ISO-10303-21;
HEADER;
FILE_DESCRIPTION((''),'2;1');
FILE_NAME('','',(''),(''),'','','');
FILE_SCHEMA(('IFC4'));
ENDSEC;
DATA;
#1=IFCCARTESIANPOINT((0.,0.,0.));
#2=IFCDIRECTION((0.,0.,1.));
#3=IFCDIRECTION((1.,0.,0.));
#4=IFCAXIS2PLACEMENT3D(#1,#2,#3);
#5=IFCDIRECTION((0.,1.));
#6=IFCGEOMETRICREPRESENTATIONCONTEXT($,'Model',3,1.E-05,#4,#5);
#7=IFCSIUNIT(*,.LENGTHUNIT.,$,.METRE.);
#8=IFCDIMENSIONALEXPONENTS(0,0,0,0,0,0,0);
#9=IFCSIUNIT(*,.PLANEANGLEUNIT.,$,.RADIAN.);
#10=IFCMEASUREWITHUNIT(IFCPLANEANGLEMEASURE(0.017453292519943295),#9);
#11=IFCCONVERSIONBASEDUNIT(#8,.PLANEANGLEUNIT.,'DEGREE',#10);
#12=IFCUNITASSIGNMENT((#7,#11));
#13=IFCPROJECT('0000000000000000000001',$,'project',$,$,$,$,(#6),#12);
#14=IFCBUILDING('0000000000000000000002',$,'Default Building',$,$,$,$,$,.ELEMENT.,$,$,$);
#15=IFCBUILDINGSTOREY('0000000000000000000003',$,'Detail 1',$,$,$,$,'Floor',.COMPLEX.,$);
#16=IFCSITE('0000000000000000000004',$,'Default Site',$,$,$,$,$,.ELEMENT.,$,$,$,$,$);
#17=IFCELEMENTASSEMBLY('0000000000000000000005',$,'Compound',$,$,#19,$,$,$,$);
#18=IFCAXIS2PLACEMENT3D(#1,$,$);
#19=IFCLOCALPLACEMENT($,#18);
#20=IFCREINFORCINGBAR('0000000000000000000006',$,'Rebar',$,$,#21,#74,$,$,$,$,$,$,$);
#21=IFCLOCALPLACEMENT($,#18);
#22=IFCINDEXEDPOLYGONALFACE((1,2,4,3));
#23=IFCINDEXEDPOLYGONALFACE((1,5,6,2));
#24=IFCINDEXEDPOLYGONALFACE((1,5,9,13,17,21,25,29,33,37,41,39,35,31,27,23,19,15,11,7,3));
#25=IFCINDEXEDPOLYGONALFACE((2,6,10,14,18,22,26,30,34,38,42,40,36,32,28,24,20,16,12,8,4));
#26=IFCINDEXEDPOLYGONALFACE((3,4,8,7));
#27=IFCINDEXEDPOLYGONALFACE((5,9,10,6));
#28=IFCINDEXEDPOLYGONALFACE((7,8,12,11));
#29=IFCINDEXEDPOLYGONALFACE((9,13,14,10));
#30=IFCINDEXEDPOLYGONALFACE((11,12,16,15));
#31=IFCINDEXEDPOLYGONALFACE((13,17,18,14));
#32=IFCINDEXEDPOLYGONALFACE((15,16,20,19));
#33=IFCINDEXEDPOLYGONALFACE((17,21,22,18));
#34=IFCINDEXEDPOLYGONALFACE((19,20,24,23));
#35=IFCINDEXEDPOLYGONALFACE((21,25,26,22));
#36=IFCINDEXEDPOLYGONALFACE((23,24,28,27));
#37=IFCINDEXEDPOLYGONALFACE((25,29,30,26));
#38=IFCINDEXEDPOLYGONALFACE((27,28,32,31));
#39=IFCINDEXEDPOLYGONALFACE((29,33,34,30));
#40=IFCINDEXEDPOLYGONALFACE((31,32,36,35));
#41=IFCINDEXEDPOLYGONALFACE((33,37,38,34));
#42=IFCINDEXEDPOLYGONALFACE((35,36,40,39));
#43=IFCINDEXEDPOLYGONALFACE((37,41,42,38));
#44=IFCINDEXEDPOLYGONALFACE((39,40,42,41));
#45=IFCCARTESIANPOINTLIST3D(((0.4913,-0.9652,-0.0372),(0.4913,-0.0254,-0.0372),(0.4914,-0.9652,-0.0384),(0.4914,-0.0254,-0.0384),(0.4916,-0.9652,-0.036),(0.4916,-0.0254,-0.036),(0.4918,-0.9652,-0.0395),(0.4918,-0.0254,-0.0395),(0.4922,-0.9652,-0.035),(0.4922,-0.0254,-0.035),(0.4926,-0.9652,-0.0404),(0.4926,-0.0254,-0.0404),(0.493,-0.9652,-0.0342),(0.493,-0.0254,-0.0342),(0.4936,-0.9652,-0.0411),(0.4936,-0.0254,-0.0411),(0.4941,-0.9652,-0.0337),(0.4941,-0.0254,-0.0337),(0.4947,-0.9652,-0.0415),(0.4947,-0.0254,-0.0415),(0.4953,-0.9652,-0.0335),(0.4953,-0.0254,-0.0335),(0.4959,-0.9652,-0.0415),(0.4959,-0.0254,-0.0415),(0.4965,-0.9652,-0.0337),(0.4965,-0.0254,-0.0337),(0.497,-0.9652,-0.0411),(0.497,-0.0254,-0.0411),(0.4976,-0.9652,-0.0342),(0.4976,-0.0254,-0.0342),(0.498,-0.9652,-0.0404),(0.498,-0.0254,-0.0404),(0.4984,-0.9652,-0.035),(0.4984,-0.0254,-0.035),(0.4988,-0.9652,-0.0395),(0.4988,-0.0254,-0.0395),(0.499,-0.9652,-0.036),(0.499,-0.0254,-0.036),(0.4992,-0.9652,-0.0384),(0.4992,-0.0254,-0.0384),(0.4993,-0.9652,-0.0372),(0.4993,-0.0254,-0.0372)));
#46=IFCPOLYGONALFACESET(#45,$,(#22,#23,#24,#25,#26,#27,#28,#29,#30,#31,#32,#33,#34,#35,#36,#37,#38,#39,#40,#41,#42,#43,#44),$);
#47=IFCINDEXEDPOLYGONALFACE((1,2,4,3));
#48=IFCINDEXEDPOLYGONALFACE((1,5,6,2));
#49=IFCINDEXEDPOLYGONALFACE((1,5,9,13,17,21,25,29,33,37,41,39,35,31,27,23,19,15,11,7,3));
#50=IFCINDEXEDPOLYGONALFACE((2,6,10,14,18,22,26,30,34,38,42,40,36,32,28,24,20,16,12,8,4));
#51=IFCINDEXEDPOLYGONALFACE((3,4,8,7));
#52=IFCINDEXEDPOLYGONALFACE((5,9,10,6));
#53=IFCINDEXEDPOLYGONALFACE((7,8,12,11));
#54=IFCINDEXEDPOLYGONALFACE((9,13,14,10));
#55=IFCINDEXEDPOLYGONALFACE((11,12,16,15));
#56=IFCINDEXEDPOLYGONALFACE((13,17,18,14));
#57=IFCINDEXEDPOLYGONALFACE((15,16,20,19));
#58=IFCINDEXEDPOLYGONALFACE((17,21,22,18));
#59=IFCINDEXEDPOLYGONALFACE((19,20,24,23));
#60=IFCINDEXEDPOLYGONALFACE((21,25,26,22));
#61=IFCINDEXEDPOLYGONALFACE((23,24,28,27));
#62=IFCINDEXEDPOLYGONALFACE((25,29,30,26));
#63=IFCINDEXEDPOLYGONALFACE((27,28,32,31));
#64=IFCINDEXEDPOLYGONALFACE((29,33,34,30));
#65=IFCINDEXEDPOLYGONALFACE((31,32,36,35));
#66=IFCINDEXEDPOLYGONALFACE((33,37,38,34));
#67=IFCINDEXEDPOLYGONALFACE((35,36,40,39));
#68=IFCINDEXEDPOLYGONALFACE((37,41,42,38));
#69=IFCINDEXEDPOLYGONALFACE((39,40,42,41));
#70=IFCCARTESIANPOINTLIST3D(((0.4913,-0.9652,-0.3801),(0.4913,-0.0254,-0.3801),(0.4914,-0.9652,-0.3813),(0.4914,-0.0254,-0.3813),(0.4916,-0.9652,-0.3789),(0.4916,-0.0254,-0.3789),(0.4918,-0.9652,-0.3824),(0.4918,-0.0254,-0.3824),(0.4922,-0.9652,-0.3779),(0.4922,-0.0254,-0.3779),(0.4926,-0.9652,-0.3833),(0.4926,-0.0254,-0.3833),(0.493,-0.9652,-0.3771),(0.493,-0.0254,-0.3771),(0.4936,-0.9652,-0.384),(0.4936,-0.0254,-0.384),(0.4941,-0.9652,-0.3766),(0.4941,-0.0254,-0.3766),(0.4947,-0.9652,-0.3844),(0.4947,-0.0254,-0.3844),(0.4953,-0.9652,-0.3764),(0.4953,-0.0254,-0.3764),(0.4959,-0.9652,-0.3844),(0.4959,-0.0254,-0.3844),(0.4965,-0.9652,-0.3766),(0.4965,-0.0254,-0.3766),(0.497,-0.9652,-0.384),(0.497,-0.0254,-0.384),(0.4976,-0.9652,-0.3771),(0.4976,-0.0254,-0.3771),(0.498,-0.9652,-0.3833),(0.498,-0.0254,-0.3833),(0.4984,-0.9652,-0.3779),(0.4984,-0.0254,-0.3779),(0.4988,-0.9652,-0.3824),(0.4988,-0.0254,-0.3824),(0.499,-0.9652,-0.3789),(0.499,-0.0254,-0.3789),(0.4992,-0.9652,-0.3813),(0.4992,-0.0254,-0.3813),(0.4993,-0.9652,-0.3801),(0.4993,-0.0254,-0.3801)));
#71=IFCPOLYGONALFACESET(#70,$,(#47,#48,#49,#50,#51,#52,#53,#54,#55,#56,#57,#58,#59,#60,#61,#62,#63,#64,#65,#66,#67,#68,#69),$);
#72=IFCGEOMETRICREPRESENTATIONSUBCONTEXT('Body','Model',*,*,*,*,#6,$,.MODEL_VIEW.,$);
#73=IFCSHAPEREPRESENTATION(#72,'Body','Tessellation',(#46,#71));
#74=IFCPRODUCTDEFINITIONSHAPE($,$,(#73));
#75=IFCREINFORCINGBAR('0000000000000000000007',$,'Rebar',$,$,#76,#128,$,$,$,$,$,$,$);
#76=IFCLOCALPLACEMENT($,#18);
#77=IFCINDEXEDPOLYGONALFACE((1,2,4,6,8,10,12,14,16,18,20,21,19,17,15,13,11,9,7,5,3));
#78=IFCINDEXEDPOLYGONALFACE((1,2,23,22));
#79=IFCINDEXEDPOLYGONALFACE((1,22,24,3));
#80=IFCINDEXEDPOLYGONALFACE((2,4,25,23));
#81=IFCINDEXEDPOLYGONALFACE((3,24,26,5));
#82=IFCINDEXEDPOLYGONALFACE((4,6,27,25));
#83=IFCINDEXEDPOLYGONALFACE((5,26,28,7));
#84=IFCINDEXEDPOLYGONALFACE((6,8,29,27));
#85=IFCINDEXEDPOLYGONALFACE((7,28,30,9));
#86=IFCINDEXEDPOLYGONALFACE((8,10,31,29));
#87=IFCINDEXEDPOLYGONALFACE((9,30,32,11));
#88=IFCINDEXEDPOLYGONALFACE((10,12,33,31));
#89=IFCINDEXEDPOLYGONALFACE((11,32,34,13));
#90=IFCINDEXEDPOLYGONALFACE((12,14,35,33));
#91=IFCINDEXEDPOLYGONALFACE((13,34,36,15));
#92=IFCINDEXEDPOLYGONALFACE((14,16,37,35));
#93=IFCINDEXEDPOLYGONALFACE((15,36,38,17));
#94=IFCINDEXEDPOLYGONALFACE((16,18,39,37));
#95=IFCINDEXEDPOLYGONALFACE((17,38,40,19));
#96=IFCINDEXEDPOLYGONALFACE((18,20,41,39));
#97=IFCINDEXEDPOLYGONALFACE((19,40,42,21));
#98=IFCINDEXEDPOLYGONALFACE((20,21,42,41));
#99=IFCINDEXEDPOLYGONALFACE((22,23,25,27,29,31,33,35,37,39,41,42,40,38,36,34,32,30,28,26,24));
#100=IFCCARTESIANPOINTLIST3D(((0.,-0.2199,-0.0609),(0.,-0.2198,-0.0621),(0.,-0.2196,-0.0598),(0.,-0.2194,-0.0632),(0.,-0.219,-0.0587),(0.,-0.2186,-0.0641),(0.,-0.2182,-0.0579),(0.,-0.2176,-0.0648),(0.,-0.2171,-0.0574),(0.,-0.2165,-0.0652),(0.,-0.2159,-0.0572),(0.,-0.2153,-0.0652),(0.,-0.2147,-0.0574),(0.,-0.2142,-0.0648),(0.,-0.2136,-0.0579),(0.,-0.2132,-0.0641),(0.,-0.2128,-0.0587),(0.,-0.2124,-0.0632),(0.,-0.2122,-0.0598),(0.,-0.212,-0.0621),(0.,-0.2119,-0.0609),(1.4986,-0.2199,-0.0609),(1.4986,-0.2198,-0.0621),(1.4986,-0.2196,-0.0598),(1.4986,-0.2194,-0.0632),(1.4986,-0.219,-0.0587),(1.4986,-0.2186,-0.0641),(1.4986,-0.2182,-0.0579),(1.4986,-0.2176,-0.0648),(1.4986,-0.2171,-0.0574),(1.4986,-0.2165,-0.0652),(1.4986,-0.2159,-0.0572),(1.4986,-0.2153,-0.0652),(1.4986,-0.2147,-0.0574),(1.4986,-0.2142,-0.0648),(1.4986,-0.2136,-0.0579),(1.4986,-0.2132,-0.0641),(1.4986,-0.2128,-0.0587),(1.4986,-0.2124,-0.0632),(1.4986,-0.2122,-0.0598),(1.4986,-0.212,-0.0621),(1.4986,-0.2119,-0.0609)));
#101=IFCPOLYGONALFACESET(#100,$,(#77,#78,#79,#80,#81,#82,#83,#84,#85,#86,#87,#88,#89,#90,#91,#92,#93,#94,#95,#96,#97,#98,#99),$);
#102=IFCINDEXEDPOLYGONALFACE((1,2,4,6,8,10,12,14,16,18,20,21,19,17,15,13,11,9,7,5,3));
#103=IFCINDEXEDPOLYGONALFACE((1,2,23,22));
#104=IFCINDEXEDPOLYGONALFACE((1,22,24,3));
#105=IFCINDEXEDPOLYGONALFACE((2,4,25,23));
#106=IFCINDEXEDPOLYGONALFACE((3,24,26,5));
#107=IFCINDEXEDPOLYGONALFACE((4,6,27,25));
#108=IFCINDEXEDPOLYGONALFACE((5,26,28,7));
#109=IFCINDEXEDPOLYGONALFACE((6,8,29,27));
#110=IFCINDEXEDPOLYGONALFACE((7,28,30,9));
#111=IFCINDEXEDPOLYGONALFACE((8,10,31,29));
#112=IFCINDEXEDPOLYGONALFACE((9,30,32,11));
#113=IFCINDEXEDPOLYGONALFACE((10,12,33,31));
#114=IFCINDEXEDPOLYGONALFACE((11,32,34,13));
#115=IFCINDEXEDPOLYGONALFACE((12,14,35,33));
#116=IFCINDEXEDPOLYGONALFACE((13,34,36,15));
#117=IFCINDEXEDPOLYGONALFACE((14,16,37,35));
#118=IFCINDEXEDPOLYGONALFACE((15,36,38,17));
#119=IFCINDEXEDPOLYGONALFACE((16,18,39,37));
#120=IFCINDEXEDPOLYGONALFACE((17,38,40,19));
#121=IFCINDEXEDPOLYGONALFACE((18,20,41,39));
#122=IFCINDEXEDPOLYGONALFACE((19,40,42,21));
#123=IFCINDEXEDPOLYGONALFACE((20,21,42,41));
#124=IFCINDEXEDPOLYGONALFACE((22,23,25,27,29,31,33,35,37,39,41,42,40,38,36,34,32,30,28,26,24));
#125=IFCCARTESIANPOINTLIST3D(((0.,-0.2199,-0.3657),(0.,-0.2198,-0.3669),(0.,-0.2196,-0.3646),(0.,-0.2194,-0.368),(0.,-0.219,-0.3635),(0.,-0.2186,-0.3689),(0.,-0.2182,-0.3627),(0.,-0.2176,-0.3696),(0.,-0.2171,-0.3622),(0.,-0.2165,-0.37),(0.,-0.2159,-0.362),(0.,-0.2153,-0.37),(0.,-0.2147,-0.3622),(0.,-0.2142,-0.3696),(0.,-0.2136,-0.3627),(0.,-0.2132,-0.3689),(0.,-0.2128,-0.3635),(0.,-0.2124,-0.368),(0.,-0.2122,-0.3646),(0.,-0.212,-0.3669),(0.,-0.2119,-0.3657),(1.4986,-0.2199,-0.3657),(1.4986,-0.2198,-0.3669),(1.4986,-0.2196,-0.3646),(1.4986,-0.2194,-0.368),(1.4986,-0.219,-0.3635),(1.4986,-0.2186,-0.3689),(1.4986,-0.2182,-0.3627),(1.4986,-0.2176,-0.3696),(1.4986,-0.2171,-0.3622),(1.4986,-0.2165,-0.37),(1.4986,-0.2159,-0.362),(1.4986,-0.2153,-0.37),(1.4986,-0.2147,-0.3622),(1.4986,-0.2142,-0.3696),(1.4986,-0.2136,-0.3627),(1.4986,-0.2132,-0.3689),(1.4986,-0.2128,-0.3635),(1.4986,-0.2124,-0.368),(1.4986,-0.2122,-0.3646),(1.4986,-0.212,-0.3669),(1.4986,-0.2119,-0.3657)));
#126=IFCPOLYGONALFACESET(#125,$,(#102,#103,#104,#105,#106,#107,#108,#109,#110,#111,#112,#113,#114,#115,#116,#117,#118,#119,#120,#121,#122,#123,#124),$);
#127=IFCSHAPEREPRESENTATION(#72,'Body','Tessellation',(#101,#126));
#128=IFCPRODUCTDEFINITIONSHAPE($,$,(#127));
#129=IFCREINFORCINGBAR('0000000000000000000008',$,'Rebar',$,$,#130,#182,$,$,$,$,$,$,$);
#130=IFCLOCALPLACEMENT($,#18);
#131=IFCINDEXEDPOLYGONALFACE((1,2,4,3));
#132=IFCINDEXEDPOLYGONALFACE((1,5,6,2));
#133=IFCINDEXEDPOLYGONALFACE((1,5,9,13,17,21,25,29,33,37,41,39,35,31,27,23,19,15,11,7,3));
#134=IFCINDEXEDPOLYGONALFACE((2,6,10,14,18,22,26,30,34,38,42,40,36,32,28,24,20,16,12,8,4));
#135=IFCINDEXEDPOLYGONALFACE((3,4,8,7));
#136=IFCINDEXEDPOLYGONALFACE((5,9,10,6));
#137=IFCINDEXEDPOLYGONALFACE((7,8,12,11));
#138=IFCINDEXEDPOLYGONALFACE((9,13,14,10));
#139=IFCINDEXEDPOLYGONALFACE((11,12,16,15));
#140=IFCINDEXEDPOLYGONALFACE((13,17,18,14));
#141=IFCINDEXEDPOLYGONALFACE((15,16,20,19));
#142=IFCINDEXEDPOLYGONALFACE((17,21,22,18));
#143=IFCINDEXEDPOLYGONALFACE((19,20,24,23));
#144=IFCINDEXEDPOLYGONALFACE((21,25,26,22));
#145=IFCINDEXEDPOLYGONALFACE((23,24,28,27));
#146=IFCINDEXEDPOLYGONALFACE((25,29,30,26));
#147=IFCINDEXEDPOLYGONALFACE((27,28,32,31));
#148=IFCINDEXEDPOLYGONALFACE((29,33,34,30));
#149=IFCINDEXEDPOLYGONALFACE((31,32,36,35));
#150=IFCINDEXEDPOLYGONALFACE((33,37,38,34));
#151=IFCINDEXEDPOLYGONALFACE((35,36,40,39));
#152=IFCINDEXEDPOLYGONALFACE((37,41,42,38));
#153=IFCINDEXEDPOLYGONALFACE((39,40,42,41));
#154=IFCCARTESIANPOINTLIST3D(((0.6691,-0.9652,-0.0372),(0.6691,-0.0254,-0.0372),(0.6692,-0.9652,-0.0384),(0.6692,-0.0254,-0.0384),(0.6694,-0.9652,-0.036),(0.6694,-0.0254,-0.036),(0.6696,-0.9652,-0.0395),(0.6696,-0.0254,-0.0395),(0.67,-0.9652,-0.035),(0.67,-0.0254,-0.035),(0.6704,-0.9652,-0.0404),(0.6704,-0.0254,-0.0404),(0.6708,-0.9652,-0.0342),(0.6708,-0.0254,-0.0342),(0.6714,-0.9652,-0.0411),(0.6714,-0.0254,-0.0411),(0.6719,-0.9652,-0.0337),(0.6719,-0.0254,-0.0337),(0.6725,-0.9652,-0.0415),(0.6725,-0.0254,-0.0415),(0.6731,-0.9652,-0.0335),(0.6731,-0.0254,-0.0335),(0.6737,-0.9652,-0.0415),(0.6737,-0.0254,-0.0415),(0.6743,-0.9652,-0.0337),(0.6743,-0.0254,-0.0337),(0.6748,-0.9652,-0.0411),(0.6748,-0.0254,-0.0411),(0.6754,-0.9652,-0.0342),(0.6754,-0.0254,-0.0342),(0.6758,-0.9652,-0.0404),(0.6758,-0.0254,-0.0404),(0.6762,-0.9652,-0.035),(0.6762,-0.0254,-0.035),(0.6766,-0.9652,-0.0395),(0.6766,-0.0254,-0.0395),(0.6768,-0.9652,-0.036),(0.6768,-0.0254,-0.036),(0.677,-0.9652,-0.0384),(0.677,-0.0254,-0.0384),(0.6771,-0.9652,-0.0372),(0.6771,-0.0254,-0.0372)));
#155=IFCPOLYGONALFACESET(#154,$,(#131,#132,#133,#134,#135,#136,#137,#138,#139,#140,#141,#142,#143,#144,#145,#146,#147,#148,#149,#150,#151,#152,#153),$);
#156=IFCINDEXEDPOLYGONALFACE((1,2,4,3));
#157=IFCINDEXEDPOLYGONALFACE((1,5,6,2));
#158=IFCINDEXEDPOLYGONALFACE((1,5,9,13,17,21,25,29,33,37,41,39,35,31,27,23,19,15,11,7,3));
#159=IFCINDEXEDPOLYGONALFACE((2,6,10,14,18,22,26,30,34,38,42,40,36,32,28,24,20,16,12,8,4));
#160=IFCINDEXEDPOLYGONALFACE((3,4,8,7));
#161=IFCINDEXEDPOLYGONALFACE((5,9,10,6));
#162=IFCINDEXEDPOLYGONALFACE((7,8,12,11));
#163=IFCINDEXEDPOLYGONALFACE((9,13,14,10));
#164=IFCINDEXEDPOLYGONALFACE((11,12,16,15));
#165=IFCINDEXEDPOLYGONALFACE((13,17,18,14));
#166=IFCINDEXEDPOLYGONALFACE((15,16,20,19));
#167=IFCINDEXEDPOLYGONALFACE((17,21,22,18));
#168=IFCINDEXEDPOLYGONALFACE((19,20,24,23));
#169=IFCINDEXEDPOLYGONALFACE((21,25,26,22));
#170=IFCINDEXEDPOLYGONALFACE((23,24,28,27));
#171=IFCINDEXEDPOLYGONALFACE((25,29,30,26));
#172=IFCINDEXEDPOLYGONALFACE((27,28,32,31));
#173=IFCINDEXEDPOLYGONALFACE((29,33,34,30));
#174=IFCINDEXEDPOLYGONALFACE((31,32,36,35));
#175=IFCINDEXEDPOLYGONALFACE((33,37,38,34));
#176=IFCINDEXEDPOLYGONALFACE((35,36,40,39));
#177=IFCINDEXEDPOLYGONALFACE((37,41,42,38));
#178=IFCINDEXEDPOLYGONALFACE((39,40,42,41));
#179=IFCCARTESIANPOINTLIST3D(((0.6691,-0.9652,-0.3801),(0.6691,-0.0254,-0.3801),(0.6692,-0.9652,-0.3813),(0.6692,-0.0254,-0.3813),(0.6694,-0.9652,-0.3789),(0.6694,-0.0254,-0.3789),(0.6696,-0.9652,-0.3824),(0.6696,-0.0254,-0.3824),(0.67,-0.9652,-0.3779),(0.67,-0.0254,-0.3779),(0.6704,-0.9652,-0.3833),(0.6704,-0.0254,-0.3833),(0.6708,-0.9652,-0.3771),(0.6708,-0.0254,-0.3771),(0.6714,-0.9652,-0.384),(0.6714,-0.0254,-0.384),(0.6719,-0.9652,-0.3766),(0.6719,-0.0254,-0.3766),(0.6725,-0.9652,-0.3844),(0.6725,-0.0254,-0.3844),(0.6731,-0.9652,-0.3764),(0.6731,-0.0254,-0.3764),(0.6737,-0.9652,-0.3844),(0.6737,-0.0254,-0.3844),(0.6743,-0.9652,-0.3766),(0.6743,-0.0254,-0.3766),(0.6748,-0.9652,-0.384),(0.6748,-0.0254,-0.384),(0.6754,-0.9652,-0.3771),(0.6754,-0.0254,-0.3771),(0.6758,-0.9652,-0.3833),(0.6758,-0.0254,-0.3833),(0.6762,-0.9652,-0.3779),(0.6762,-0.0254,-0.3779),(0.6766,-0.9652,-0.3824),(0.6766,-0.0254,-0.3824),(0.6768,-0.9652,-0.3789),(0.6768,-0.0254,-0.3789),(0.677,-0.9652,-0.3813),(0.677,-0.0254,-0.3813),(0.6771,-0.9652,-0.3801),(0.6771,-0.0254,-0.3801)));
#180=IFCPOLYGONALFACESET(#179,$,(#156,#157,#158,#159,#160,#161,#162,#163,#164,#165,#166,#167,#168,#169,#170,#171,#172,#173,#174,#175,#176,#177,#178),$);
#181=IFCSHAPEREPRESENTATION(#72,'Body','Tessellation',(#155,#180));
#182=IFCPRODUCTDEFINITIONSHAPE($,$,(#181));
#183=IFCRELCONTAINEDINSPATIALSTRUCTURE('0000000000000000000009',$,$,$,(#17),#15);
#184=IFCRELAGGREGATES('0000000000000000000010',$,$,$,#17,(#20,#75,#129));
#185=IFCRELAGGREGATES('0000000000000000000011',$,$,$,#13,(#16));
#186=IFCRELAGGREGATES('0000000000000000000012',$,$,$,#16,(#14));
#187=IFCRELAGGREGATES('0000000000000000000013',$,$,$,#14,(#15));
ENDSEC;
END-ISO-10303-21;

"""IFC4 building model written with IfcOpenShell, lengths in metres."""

from ifc_helpers import new_model, entity, si_unit, converted_unit, direction, origin_with_axes, place, context, subcontext, project, spatial, element, aggregate, save


model = new_model("IFC4")

# Units and contexts
model_context = context("Model", 3, precision=1e-05, world=origin_with_axes(), true_north=direction((0.0, 1.0)))
body_context = subcontext(model_context, "Body", "Model", "MODEL_VIEW")
ifc_project = project(units=[si_unit("LENGTHUNIT", "METRE"), converted_unit("PLANEANGLEUNIT", "DEGREE", entity("IfcPlaneAngleMeasure", 0.017453292519943295), si_unit("PLANEANGLEUNIT", "RADIAN"), dimensions=[0, 0, 0, 0, 0, 0, 0])], contexts=[model_context])

# Site, building, storey
site = spatial("IfcSite", under=ifc_project, Name="Default Site", CompositionType="ELEMENT")
building = spatial("IfcBuilding", under=site, Name="Default Building", CompositionType="ELEMENT")
storey = spatial("IfcBuildingStorey", under=building, Name="Detail 1", LongName="Floor", CompositionType="COMPLEX")

# Shared definitions
placement = place(None, origin_with_axes())

# Element assembly, reinforcing bars
assembly = element("IfcElementAssembly", 1, inside=storey, Name="Compound")
reinforcing_bar_1 = element("IfcReinforcingBar", 2, at=placement, Name="Rebar", context=body_context, shape_type="SweptSolid", body=[
    entity("IfcSweptDiskSolid", entity("IfcCompositeCurve", [entity("IfcCompositeCurveSegment", "CONTINUOUS", True, entity("IfcPolyline", [entity("IfcCartesianPoint", [0.4953, -0.9652, -0.0375]), entity("IfcCartesianPoint", [0.4953, -0.0254, -0.0375])]))], False), 0.004),
    entity("IfcSweptDiskSolid", entity("IfcCompositeCurve", [entity("IfcCompositeCurveSegment", "CONTINUOUS", True, entity("IfcPolyline", [entity("IfcCartesianPoint", [0.4953, -0.9652, -0.3804]), entity("IfcCartesianPoint", [0.4953, -0.0254, -0.3804])]))], False), 0.004),
])
reinforcing_bar_2 = element("IfcReinforcingBar", 3, at=placement, Name="Rebar", context=body_context, shape_type="SweptSolid", body=[
    entity("IfcSweptDiskSolid", entity("IfcCompositeCurve", [entity("IfcCompositeCurveSegment", "CONTINUOUS", True, entity("IfcPolyline", [entity("IfcCartesianPoint", [0.0, -0.2159, -0.0612]), entity("IfcCartesianPoint", [1.4986, -0.2159, -0.0612])]))], False), 0.004),
    entity("IfcSweptDiskSolid", entity("IfcCompositeCurve", [entity("IfcCompositeCurveSegment", "CONTINUOUS", True, entity("IfcPolyline", [entity("IfcCartesianPoint", [0.0, -0.2159, -0.366]), entity("IfcCartesianPoint", [1.4986, -0.2159, -0.366])]))], False), 0.004),
])
reinforcing_bar_3 = element("IfcReinforcingBar", 4, at=placement, Name="Rebar", context=body_context, shape_type="SweptSolid", body=[
    entity("IfcSweptDiskSolid", entity("IfcCompositeCurve", [entity("IfcCompositeCurveSegment", "CONTINUOUS", True, entity("IfcPolyline", [entity("IfcCartesianPoint", [0.6731, -0.9652, -0.0375]), entity("IfcCartesianPoint", [0.6731, -0.0254, -0.0375])]))], False), 0.004),
    entity("IfcSweptDiskSolid", entity("IfcCompositeCurve", [entity("IfcCompositeCurveSegment", "CONTINUOUS", True, entity("IfcPolyline", [entity("IfcCartesianPoint", [0.6731, -0.9652, -0.3804]), entity("IfcCartesianPoint", [0.6731, -0.0254, -0.3804])]))], False), 0.004),
])
aggregate(assembly, [reinforcing_bar_1, reinforcing_bar_2, reinforcing_bar_3])

save(model, "model.ifc")
